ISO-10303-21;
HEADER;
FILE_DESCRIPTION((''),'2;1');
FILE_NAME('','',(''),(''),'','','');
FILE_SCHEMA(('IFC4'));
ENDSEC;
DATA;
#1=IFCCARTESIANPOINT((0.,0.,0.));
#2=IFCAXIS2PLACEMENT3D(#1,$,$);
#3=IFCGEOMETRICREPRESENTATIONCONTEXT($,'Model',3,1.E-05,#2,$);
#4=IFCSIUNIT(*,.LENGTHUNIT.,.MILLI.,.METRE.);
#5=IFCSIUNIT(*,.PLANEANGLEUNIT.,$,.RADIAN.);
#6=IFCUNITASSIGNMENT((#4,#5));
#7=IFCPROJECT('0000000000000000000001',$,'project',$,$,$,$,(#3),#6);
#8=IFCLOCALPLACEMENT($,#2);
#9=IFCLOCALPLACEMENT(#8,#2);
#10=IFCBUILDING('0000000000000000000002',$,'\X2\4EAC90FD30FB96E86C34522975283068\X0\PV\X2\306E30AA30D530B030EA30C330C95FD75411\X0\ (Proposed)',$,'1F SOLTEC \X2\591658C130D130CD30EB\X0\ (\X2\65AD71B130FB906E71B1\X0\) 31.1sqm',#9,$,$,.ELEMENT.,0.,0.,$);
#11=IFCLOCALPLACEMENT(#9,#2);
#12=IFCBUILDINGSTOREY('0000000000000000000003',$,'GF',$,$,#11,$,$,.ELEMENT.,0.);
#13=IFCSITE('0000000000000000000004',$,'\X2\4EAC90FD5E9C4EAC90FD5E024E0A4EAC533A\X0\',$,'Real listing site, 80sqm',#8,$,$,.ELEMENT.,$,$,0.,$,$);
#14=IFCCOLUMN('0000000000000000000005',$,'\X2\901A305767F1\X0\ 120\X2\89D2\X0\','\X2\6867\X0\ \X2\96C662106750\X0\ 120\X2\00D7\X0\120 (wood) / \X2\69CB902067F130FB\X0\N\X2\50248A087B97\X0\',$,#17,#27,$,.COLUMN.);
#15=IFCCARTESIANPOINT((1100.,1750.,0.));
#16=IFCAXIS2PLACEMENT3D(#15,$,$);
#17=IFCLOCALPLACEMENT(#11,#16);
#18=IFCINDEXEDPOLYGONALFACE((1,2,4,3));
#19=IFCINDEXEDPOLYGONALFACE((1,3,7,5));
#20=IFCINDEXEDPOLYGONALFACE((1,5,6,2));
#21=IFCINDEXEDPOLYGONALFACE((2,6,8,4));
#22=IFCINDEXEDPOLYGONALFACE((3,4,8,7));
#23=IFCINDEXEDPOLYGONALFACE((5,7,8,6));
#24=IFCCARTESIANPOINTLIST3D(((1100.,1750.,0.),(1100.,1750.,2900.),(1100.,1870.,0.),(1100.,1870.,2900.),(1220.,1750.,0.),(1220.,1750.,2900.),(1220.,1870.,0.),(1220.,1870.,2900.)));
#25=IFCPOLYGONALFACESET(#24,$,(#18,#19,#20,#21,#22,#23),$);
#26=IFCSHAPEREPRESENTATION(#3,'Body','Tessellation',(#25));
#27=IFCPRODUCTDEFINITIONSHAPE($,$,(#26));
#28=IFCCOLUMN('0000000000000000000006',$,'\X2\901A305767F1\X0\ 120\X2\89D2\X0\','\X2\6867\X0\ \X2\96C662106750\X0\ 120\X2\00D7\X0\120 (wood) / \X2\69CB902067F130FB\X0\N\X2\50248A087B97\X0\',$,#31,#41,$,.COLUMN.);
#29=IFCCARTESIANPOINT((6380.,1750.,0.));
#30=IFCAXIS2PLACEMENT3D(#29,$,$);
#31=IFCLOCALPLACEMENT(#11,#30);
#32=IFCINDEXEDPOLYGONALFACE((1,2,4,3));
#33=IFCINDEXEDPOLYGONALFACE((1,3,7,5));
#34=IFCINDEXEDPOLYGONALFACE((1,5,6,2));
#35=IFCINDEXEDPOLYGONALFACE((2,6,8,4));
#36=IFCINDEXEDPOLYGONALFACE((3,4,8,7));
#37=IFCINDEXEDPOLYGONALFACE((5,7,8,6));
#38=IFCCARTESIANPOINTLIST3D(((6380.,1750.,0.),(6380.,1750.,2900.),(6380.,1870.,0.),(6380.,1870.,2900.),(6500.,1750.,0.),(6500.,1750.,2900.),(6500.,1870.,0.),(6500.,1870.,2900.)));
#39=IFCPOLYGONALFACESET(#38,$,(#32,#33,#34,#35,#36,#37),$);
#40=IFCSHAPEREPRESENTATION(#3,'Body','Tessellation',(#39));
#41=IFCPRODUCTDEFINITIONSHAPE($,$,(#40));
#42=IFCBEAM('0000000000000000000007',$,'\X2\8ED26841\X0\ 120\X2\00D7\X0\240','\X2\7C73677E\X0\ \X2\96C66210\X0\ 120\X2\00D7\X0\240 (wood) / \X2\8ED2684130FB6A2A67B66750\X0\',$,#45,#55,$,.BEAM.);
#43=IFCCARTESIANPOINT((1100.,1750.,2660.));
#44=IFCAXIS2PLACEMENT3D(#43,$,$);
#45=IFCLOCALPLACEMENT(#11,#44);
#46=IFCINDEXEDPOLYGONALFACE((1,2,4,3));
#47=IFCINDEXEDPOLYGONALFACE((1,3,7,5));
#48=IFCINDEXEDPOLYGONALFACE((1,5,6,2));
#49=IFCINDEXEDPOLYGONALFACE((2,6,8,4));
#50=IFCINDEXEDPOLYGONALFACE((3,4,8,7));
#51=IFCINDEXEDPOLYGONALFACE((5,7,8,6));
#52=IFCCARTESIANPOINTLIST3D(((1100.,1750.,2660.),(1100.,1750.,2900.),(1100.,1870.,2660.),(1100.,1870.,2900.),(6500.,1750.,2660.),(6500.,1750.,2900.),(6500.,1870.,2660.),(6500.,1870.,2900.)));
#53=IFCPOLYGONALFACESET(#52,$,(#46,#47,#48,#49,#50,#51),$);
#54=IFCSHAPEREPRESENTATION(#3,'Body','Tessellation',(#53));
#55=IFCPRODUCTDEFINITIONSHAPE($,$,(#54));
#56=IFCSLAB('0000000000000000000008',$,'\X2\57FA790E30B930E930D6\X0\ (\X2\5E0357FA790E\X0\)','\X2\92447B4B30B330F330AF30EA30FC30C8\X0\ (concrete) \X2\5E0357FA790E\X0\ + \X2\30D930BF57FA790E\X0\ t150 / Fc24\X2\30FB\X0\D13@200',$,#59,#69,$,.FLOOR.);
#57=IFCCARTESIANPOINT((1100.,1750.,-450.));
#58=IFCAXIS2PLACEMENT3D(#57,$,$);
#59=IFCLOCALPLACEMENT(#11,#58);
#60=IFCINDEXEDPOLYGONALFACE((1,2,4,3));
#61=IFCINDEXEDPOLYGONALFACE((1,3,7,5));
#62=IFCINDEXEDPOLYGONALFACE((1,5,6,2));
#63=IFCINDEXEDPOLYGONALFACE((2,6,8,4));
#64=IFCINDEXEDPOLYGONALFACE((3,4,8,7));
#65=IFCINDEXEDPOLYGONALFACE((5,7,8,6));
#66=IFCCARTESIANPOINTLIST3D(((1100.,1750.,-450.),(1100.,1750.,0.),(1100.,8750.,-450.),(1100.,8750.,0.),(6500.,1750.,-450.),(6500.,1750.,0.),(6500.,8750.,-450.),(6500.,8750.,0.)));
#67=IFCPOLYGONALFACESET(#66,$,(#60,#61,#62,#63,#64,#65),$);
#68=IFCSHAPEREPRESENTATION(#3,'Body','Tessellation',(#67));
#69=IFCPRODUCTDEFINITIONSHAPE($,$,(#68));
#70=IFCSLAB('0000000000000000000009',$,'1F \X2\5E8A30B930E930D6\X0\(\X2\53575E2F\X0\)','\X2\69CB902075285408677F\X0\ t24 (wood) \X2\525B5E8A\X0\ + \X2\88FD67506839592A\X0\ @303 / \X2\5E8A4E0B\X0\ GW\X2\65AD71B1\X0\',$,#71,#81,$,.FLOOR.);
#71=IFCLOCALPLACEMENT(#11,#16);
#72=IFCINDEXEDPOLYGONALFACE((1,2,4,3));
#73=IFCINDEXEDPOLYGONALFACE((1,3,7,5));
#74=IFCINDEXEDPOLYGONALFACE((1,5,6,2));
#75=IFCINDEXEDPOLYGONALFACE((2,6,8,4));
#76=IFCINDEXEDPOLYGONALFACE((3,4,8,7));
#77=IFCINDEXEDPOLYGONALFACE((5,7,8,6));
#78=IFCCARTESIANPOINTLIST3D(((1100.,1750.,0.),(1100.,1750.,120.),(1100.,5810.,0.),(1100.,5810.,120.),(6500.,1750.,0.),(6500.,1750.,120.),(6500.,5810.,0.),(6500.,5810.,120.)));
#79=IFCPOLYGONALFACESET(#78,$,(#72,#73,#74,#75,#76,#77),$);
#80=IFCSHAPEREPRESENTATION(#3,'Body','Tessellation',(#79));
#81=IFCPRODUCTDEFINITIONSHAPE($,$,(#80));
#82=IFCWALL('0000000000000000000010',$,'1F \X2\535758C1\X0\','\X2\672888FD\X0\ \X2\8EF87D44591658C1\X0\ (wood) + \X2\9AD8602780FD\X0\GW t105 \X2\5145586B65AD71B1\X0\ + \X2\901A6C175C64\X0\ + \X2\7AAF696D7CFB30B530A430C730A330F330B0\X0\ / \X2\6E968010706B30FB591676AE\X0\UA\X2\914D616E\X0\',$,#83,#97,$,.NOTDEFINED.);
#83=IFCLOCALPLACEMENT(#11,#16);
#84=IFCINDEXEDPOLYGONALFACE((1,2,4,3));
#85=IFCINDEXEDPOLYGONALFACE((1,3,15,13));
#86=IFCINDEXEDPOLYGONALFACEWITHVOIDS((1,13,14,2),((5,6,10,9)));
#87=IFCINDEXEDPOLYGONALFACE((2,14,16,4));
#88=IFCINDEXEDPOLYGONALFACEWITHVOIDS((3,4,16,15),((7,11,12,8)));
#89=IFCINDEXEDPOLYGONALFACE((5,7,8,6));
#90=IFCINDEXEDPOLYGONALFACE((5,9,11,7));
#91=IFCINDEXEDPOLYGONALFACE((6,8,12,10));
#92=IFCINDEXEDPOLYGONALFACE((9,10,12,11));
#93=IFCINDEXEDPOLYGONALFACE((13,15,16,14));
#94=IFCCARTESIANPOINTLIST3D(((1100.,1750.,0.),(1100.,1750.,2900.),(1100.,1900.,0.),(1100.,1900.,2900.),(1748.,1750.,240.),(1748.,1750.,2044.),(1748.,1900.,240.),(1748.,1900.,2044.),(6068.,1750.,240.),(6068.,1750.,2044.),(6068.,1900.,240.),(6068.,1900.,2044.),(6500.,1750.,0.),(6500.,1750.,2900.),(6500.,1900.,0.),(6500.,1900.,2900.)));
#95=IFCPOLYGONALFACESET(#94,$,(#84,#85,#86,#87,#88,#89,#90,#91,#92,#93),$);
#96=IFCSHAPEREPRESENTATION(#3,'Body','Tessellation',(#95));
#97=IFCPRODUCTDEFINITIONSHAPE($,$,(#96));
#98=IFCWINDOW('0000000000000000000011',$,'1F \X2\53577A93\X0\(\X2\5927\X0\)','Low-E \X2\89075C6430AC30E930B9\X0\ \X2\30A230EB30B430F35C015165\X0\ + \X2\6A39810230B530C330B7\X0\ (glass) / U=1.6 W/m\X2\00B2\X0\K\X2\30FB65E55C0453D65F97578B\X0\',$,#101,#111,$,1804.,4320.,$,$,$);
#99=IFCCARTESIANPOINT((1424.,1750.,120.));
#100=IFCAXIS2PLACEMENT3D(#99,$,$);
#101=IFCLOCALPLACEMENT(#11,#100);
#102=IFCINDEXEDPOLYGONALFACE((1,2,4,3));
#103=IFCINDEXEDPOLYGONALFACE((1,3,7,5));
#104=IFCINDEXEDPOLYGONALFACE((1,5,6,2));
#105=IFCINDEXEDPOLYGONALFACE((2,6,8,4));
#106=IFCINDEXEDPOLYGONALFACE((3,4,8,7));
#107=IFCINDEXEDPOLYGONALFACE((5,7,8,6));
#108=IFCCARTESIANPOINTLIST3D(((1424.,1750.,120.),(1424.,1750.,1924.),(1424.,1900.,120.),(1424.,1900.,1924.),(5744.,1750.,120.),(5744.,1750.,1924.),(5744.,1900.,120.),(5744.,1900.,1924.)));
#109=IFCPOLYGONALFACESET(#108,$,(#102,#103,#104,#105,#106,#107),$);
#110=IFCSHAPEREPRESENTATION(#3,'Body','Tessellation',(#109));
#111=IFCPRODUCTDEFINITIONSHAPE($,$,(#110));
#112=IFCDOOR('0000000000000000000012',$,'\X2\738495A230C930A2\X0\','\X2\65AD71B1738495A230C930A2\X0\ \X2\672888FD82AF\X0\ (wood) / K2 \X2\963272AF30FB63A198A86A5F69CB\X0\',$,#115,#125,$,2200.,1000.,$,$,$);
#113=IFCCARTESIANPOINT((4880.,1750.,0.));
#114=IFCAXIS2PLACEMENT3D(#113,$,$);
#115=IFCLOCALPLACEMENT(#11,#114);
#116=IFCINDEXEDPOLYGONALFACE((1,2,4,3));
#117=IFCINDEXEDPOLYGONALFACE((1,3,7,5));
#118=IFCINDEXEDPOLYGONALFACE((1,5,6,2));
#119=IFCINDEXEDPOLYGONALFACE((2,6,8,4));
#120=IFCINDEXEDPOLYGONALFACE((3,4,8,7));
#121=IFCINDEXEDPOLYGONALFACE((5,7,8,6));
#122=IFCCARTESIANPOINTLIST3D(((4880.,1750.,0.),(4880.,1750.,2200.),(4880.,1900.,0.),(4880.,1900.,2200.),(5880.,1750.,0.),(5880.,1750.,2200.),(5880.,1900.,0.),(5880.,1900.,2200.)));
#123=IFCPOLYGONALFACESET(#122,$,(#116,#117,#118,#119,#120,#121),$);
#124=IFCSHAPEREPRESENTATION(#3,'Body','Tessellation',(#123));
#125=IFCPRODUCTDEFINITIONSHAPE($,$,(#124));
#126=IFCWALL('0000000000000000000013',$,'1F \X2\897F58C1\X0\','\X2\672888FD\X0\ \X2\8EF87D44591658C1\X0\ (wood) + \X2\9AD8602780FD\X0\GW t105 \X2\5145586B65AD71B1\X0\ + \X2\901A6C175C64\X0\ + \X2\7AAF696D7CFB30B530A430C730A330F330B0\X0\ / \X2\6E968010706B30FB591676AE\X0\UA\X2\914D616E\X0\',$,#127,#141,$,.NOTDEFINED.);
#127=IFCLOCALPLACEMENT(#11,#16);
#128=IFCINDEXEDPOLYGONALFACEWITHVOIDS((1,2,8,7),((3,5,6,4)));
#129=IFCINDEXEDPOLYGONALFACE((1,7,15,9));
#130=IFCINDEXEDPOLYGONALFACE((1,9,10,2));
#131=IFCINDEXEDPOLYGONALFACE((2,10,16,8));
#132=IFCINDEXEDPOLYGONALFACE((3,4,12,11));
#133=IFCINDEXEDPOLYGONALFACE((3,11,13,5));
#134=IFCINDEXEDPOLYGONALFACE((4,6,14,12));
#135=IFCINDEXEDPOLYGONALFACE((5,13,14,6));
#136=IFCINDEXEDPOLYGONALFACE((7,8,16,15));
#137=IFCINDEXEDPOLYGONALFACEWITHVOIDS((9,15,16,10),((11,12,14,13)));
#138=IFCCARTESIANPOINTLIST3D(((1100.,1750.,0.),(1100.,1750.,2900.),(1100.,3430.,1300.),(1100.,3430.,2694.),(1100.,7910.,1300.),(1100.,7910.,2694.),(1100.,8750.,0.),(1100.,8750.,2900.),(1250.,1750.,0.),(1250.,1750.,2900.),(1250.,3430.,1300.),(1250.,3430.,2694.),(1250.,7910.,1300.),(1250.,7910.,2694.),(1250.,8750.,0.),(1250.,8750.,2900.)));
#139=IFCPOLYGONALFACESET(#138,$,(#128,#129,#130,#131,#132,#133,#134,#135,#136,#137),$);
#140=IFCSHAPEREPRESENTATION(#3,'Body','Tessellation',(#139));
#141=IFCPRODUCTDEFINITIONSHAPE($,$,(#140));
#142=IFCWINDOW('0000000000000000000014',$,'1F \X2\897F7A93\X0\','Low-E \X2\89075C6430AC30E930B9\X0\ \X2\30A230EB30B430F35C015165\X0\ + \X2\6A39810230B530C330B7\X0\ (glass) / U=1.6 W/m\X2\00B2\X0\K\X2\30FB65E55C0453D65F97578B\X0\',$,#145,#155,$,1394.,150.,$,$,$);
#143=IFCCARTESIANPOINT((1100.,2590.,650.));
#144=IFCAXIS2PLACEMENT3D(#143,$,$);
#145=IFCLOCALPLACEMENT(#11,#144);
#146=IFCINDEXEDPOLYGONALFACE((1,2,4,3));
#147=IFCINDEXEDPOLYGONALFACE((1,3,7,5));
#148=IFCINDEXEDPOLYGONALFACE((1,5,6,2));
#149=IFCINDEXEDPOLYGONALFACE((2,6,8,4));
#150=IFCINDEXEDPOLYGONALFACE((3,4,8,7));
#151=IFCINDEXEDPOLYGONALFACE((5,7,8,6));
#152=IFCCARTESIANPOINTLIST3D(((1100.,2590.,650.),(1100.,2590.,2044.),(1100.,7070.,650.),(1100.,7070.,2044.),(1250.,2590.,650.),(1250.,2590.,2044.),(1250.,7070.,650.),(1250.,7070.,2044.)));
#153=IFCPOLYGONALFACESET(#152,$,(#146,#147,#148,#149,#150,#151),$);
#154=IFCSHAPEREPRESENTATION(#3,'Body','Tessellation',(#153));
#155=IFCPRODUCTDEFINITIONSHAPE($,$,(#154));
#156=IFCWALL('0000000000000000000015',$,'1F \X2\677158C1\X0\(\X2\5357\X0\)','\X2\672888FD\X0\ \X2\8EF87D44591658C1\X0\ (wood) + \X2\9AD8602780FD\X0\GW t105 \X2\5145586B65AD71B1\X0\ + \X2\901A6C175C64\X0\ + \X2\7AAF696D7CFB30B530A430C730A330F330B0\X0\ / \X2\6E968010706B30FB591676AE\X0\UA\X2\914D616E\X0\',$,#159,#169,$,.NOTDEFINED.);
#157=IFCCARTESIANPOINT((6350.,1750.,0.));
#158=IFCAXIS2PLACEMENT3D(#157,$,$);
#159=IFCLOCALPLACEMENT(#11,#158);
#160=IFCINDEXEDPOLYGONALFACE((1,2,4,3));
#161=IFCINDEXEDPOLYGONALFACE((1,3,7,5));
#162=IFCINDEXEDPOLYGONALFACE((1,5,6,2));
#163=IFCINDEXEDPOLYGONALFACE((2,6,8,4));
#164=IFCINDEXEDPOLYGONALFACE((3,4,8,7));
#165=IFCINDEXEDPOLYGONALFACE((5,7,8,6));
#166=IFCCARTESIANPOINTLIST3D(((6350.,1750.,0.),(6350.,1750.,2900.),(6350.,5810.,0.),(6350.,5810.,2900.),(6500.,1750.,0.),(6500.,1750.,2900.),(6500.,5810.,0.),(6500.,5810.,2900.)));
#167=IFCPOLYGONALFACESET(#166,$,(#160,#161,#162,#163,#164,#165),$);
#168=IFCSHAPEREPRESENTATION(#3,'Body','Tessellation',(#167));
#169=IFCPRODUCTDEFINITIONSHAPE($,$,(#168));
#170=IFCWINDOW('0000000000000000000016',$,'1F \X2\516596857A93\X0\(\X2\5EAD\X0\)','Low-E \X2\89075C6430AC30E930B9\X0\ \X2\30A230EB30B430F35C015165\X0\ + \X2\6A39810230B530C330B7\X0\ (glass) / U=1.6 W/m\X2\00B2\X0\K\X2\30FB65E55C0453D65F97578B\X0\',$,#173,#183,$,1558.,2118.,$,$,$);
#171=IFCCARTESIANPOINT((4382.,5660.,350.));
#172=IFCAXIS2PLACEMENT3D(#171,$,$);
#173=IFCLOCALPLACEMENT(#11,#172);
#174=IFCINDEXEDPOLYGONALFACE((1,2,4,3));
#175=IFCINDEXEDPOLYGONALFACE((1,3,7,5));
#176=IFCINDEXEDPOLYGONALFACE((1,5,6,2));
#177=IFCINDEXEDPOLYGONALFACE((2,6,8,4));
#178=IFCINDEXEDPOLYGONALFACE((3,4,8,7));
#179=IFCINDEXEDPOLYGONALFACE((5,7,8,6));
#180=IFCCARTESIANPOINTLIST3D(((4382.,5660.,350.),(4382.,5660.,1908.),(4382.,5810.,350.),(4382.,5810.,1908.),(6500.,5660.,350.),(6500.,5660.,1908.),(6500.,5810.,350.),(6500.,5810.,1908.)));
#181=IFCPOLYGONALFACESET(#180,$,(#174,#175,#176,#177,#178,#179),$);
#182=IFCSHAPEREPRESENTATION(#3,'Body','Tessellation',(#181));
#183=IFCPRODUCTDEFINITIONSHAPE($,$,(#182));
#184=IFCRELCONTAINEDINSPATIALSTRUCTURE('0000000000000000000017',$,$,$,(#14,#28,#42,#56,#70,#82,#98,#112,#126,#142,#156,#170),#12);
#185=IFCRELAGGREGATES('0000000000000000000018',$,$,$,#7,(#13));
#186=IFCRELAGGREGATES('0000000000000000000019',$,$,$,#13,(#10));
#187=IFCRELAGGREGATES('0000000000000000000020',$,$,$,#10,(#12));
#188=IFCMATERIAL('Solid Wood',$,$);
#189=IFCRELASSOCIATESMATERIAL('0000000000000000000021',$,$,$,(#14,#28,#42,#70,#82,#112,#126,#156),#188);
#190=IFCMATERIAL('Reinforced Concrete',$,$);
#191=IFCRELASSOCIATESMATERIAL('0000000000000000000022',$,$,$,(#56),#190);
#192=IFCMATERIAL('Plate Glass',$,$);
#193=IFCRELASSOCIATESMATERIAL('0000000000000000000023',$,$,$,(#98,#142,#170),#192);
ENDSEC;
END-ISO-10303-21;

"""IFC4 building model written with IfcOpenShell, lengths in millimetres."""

from ifc_helpers import new_model, si_unit, frame, frame_2d, origin, place, context, project, spatial, rectangle, extrude, material, element, fill, save


model = new_model("IFC4")

# Units and contexts
model_context = context("Model", 3, precision=1e-05, world=origin())
ifc_project = project(units=[si_unit("LENGTHUNIT", "METRE", prefix="MILLI"), si_unit("PLANEANGLEUNIT", "RADIAN")], contexts=[model_context])

# Site, building, storey
site_placement = place(None, origin())
site = spatial("IfcSite", under=ifc_project, at=site_placement, Name="京都府京都市上京区", ObjectType="Real listing site, 80sqm", CompositionType="ELEMENT", RefElevation=0.0)
building_placement = place(site_placement, origin())
building = spatial("IfcBuilding", under=site, at=building_placement, Name="京都・雨水利用とPVのオフグリッド志向 (Proposed)", ObjectType="1F SOLTEC 外壁パネル (断熱・遮熱) 31.1sqm", CompositionType="ELEMENT", ElevationOfRefHeight=0.0, ElevationOfTerrain=0.0)
storey_placement = place(building_placement, origin())
storey = spatial("IfcBuildingStorey", under=building, at=storey_placement, Name="GF", CompositionType="ELEMENT", Elevation=0.0)

# Columns
ifc_material_1 = material(Name="Solid Wood")
column_1_placement = place(storey_placement, frame((1100.0, 1750.0, 0.0)))
element("IfcColumn", 1, at=column_1_placement, inside=storey, material=ifc_material_1, Name="通し柱 120角", Description="桧 集成材 120×120 (wood) / 構造柱・N値計算", PredefinedType="COLUMN", context=model_context, shape_type="SweptSolid", body=[
    extrude(rectangle(XDim=120.0, YDim=120.0, at=frame_2d((60.0, 60.0))), frame((1100.0, 1750.0, 0.0)), (0.0, 0.0, 1.0), 2900.0),
])
column_2_placement = place(storey_placement, frame((6380.0, 1750.0, 0.0)))
element("IfcColumn", 2, at=column_2_placement, inside=storey, material=ifc_material_1, Name="通し柱 120角", Description="桧 集成材 120×120 (wood) / 構造柱・N値計算", PredefinedType="COLUMN", context=model_context, shape_type="SweptSolid", body=[
    extrude(rectangle(XDim=120.0, YDim=120.0, at=frame_2d((60.0, 60.0))), frame((6380.0, 1750.0, 0.0)), (0.0, 0.0, 1.0), 2900.0),
])

# Beam
beam_1_placement = place(storey_placement, frame((1100.0, 1750.0, 2660.0)))
element("IfcBeam", 3, at=beam_1_placement, inside=storey, material=ifc_material_1, Name="軒桁 120×240", Description="米松 集成 120×240 (wood) / 軒桁・横架材", PredefinedType="BEAM", context=model_context, shape_type="SweptSolid", body=[
    extrude(rectangle(XDim=5400.0, YDim=120.0, at=frame_2d((2700.0, 60.0))), frame((1100.0, 1750.0, 2660.0)), (0.0, 0.0, 1.0), 240.0),
])

# Slabs
ifc_material_2 = material(Name="Reinforced Concrete")
slab_1_placement = place(storey_placement, frame((1100.0, 1750.0, -450.0)))
element("IfcSlab", 4, at=slab_1_placement, inside=storey, material=ifc_material_2, Name="基礎スラブ (布基礎)", Description="鉄筋コンクリート (concrete) 布基礎 + ベタ基礎 t150 / Fc24・D13@200", PredefinedType="FLOOR", context=model_context, shape_type="SweptSolid", body=[
    extrude(rectangle(XDim=5400.0, YDim=7000.0, at=frame_2d((2700.0, 3500.0))), frame((1100.0, 1750.0, -450.0)), (0.0, 0.0, 1.0), 450.0),
])
slab_2_placement = place(storey_placement, frame((1100.0, 1750.0, 0.0)))
element("IfcSlab", 5, at=slab_2_placement, inside=storey, material=ifc_material_1, Name="1F 床スラブ(南帯)", Description="構造用合板 t24 (wood) 剛床 + 製材根太 @303 / 床下 GW断熱", PredefinedType="FLOOR", context=model_context, shape_type="SweptSolid", body=[
    extrude(rectangle(XDim=5400.0, YDim=4060.0, at=frame_2d((2700.0, 2030.0))), frame((1100.0, 1750.0, 0.0)), (0.0, 0.0, 1.0), 120.0),
])

# Wall, openings, window, door
wall_1_placement = place(storey_placement, frame((1100.0, 1750.0, 0.0)))
wall_1 = element("IfcWall", 6, at=wall_1_placement, inside=storey, material=ifc_material_1, Name="1F 南壁", Description="木製 軸組外壁 (wood) + 高性能GW t105 充填断熱 + 通気層 + 窯業系サイディング / 準耐火・外皮UA配慮", PredefinedType="NOTDEFINED", context=model_context, shape_type="SweptSolid", body=[
    extrude(rectangle(XDim=5400.0, YDim=150.0, at=frame_2d((2700.0, 75.0))), frame((1100.0, 1750.0, 0.0)), (0.0, 0.0, 1.0), 2900.0),
])
opening_1_placement = place(storey_placement, frame((1424.0, 1750.0, 120.0)))
opening_1 = element("IfcOpeningElement", 7, at=opening_1_placement, cuts=wall_1, PredefinedType="NOTDEFINED", context=model_context, shape_type="SweptSolid", body=[
    extrude(rectangle(XDim=4320.0, YDim=150.0, at=frame_2d((2160.0, 75.0))), frame((1424.0, 1750.0, 120.0)), (0.0, 0.0, 1.0), 1804.0),
])
opening_2_placement = place(storey_placement, frame((4880.0, 1750.0, 0.0)))
opening_2 = element("IfcOpeningElement", 8, at=opening_2_placement, cuts=wall_1, PredefinedType="NOTDEFINED", context=model_context, shape_type="SweptSolid", body=[
    extrude(rectangle(XDim=1000.0, YDim=150.0, at=frame_2d((500.0, 75.0))), frame((4880.0, 1750.0, 0.0)), (0.0, 0.0, 1.0), 2200.0),
])
ifc_material_3 = material(Name="Plate Glass")
window_1_placement = place(storey_placement, frame((1424.0, 1750.0, 120.0)))
window_1 = element("IfcWindow", 9, at=window_1_placement, inside=storey, material=ifc_material_3, Name="1F 南窓(大)", Description="Low-E 複層ガラス アルゴン封入 + 樹脂サッシ (glass) / U=1.6 W/m²K・日射取得型", OverallHeight=1804.0, OverallWidth=4320.0, context=model_context, shape_type="SweptSolid", body=[
    extrude(rectangle(XDim=4320.0, YDim=150.0, at=frame_2d((2160.0, 75.0))), frame((1424.0, 1750.0, 120.0)), (0.0, 0.0, 1.0), 1804.0),
])
fill(opening_1, window_1)
door_1_placement = place(storey_placement, frame((4880.0, 1750.0, 0.0)))
door_1 = element("IfcDoor", 10, at=door_1_placement, inside=storey, material=ifc_material_1, Name="玄関ドア", Description="断熱玄関ドア 木製芯 (wood) / K2 防犯・採風機構", OverallHeight=2200.0, OverallWidth=1000.0, context=model_context, shape_type="SweptSolid", body=[
    extrude(rectangle(XDim=1000.0, YDim=150.0, at=frame_2d((500.0, 75.0))), frame((4880.0, 1750.0, 0.0)), (0.0, 0.0, 1.0), 2200.0),
])
fill(opening_2, door_1)

# Walls, openings, windows
wall_2_placement = place(storey_placement, frame((1100.0, 1750.0, 0.0)))
wall_2 = element("IfcWall", 11, at=wall_2_placement, inside=storey, material=ifc_material_1, Name="1F 西壁", Description="木製 軸組外壁 (wood) + 高性能GW t105 充填断熱 + 通気層 + 窯業系サイディング / 準耐火・外皮UA配慮", PredefinedType="NOTDEFINED", context=model_context, shape_type="SweptSolid", body=[
    extrude(rectangle(XDim=150.0, YDim=7000.0, at=frame_2d((75.0, 3500.0))), frame((1100.0, 1750.0, 0.0)), (0.0, 0.0, 1.0), 2900.0),
])
opening_3_placement = place(storey_placement, frame((1100.0, 2590.0, 650.0)))
opening_3 = element("IfcOpeningElement", 12, at=opening_3_placement, cuts=wall_2, PredefinedType="NOTDEFINED", context=model_context, shape_type="SweptSolid", body=[
    extrude(rectangle(XDim=150.0, YDim=4480.0, at=frame_2d((75.0, 2240.0))), frame((1100.0, 2590.0, 650.0)), (0.0, 0.0, 1.0), 1394.0),
])
window_2_placement = place(storey_placement, frame((1100.0, 2590.0, 650.0)))
window_2 = element("IfcWindow", 13, at=window_2_placement, inside=storey, material=ifc_material_3, Name="1F 西窓", Description="Low-E 複層ガラス アルゴン封入 + 樹脂サッシ (glass) / U=1.6 W/m²K・日射取得型", OverallHeight=1394.0, OverallWidth=150.0, context=model_context, shape_type="SweptSolid", body=[
    extrude(rectangle(XDim=150.0, YDim=4480.0, at=frame_2d((75.0, 2240.0))), frame((1100.0, 2590.0, 650.0)), (0.0, 0.0, 1.0), 1394.0),
])
fill(opening_3, window_2)
wall_3_placement = place(storey_placement, frame((6350.0, 1750.0, 0.0)))
wall_3 = element("IfcWall", 14, at=wall_3_placement, inside=storey, material=ifc_material_1, Name="1F 東壁(南)", Description="木製 軸組外壁 (wood) + 高性能GW t105 充填断熱 + 通気層 + 窯業系サイディング / 準耐火・外皮UA配慮", PredefinedType="NOTDEFINED", context=model_context, shape_type="SweptSolid", body=[
    extrude(rectangle(XDim=150.0, YDim=4060.0, at=frame_2d((75.0, 2030.0))), frame((6350.0, 1750.0, 0.0)), (0.0, 0.0, 1.0), 2900.0),
])
opening_4_placement = place(storey_placement, frame((4382.0, 5660.0, 350.0)))
opening_4 = element("IfcOpeningElement", 15, at=opening_4_placement, cuts=wall_3, PredefinedType="NOTDEFINED", context=model_context, shape_type="SweptSolid", body=[
    extrude(rectangle(XDim=2118.0, YDim=150.0, at=frame_2d((1059.0, 75.0))), frame((4382.0, 5660.0, 350.0)), (0.0, 0.0, 1.0), 1558.0),
])
window_3_placement = place(storey_placement, frame((4382.0, 5660.0, 350.0)))
window_3 = element("IfcWindow", 16, at=window_3_placement, inside=storey, material=ifc_material_3, Name="1F 入隅窓(庭)", Description="Low-E 複層ガラス アルゴン封入 + 樹脂サッシ (glass) / U=1.6 W/m²K・日射取得型", OverallHeight=1558.0, OverallWidth=2118.0, context=model_context, shape_type="SweptSolid", body=[
    extrude(rectangle(XDim=2118.0, YDim=150.0, at=frame_2d((1059.0, 75.0))), frame((4382.0, 5660.0, 350.0)), (0.0, 0.0, 1.0), 1558.0),
])
fill(opening_4, window_3)

save(model, "model.ifc")
